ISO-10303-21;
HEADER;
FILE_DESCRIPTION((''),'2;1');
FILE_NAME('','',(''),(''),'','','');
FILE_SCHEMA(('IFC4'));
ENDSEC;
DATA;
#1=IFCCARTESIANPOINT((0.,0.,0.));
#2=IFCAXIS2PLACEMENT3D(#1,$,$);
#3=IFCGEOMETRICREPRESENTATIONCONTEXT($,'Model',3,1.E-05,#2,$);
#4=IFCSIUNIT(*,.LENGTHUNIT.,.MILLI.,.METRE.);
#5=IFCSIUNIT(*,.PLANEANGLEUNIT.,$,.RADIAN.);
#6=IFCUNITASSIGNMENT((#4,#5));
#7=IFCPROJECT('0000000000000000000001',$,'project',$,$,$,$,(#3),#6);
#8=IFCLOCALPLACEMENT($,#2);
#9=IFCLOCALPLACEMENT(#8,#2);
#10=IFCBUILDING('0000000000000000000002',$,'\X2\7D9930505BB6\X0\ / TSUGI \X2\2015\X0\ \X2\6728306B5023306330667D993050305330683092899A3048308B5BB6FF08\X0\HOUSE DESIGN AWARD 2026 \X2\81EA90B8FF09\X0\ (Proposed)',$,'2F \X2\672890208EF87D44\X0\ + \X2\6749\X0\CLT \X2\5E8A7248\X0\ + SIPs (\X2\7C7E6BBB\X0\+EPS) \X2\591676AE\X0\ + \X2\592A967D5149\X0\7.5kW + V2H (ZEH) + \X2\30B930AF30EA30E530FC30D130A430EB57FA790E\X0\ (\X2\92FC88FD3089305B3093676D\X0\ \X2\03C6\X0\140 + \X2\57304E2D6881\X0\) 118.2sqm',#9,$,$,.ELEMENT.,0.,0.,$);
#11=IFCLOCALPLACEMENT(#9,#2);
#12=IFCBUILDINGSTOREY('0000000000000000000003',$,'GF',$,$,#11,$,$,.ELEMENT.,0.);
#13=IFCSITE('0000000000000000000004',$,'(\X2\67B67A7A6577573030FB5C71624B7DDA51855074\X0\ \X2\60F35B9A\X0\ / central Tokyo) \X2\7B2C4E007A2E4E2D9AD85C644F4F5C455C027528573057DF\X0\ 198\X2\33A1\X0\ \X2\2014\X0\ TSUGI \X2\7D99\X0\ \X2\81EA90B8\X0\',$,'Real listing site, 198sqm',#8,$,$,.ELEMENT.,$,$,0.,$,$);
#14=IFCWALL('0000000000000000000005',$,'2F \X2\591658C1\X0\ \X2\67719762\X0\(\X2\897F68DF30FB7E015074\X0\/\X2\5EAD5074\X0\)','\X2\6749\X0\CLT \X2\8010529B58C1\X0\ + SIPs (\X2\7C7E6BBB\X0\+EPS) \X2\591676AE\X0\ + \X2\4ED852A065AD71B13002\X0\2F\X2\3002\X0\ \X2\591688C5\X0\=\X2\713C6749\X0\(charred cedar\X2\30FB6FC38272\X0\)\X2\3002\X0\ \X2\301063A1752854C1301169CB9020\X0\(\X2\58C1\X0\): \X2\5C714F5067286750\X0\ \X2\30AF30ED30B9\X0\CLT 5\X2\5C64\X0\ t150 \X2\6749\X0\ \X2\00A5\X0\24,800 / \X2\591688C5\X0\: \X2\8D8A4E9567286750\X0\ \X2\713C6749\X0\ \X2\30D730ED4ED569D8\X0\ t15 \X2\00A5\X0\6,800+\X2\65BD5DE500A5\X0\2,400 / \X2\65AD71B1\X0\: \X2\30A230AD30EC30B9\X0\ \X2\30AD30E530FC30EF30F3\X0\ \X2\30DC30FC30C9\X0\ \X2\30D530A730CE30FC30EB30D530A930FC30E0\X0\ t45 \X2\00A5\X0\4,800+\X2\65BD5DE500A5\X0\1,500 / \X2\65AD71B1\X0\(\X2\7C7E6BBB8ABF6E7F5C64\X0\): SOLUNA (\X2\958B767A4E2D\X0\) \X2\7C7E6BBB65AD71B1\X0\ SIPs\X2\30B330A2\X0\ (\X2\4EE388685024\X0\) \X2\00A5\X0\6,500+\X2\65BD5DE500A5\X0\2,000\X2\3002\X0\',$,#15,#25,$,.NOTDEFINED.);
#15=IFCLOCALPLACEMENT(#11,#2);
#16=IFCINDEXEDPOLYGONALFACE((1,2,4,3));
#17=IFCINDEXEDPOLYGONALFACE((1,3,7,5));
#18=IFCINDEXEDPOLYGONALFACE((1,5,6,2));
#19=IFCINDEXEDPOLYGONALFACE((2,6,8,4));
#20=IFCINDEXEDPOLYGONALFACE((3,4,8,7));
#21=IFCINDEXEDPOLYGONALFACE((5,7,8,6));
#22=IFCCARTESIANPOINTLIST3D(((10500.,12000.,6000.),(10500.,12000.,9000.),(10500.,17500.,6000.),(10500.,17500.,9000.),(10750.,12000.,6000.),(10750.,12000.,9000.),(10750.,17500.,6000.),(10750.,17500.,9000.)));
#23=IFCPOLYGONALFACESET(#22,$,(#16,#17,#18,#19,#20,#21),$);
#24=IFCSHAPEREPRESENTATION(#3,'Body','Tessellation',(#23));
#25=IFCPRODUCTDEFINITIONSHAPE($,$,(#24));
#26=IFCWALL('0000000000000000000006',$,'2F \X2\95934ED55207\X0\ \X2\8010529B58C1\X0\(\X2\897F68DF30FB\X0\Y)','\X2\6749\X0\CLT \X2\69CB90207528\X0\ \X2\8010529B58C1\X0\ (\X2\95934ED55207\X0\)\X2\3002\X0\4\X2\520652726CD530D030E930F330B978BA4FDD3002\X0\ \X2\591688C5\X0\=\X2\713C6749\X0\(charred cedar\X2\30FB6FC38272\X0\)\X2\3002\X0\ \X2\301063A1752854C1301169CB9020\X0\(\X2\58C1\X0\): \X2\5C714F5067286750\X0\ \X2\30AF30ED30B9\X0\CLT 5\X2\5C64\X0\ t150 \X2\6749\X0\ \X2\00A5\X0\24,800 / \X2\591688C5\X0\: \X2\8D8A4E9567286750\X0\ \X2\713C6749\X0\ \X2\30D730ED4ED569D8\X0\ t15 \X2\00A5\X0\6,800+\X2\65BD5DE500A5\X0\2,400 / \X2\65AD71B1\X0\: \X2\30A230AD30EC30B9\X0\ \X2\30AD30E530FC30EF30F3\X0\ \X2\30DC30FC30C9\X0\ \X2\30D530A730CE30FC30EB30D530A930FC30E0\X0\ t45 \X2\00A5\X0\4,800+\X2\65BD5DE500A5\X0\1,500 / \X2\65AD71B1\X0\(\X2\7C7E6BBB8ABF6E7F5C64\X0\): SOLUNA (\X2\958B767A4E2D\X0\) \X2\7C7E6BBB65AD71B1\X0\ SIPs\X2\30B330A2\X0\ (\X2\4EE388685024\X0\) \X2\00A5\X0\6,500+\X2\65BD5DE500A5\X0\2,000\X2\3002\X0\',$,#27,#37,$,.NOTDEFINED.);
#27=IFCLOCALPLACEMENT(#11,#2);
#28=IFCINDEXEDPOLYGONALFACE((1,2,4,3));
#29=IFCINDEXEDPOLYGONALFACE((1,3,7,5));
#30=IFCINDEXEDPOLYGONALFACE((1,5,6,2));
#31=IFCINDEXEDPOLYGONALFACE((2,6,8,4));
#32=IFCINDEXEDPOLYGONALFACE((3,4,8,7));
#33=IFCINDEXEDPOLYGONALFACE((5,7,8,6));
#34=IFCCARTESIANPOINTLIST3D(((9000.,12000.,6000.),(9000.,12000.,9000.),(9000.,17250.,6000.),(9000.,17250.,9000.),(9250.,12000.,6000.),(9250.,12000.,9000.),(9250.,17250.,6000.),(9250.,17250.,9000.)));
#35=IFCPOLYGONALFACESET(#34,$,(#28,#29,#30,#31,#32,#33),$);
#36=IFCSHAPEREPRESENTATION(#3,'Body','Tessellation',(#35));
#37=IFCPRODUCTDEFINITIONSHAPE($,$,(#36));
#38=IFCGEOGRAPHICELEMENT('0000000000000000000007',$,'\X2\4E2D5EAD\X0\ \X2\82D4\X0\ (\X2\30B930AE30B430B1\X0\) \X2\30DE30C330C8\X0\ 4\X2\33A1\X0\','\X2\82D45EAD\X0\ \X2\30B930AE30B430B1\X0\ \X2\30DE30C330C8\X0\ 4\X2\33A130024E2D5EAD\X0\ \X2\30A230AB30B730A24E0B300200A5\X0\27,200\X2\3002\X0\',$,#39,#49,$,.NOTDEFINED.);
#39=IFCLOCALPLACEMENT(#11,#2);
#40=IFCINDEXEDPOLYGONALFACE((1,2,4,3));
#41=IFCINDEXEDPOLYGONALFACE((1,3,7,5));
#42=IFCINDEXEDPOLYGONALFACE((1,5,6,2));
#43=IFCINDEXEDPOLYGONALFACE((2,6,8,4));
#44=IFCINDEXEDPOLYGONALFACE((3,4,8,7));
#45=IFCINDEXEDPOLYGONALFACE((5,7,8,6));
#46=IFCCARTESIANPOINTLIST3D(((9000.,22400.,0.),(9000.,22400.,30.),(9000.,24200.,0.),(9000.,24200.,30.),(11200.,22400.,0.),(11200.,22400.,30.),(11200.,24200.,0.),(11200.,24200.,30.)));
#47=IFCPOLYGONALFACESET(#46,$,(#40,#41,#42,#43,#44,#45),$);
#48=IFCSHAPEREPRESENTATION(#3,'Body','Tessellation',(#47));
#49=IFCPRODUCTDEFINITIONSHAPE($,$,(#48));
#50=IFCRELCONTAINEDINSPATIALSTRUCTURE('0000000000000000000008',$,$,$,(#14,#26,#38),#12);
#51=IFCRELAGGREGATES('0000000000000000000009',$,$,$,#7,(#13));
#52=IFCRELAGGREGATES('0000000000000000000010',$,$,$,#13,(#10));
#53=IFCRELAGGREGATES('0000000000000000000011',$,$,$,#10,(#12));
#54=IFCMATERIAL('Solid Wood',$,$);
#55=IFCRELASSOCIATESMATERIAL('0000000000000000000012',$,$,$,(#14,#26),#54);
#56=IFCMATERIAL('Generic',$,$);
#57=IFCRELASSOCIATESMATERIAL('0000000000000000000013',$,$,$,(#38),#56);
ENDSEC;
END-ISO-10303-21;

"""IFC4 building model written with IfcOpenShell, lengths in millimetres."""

from ifc_helpers import new_model, si_unit, frame, frame_2d, origin, place, context, project, spatial, rectangle, extrude, material, element, save


model = new_model("IFC4")

# Units and contexts
model_context = context("Model", 3, precision=1e-05, world=origin())
ifc_project = project(units=[si_unit("LENGTHUNIT", "METRE", prefix="MILLI"), si_unit("PLANEANGLEUNIT", "RADIAN")], contexts=[model_context])

# Site, building, storey
site_placement = place(None, origin())
site = spatial("IfcSite", under=ifc_project, at=site_placement, Name="(架空敷地・山手線内側 想定 / central Tokyo) 第一種中高層住居専用地域 198㎡ — TSUGI 継 自邸", ObjectType="Real listing site, 198sqm", CompositionType="ELEMENT", RefElevation=0.0)
building_placement = place(site_placement, origin())
building = spatial("IfcBuilding", under=site, at=building_placement, Name="継ぐ家 / TSUGI ― 木に倣って継ぐことを覚える家（HOUSE DESIGN AWARD 2026 自邸） (Proposed)", ObjectType="2F 木造軸組 + 杉CLT 床版 + SIPs (籾殻+EPS) 外皮 + 太陽光7.5kW + V2H (ZEH) + スクリューパイル基礎 (鋼製らせん杭 φ140 + 地中梁) 118.2sqm", CompositionType="ELEMENT", ElevationOfRefHeight=0.0, ElevationOfTerrain=0.0)
storey_placement = place(building_placement, origin())
storey = spatial("IfcBuildingStorey", under=building, at=storey_placement, Name="GF", CompositionType="ELEMENT", Elevation=0.0)

# Shared definitions
ifc_material_1 = material(Name="Generic")

# Shared definitions
ifc_material_2 = material(Name="Solid Wood")

# Walls
wall_1_placement = place(storey_placement, frame((5250.0, 6000.0, 3000.0)))
element("IfcWall", 1, at=wall_1_placement, inside=storey, material=ifc_material_2, Name="2F 外壁 東面(西棟・縁側/庭側)", Description="杉CLT 耐力壁 + SIPs (籾殻+EPS) 外皮 + 付加断熱。2F。 外装=焼杉(charred cedar・濃色)。 【採用品】構造(壁): 山佐木材 クロスCLT 5層 t150 杉 ¥24,800 / 外装: 越井木材 焼杉 プロ仕様 t15 ¥6,800+施工¥2,400 / 断熱: アキレス キューワン ボード フェノールフォーム t45 ¥4,800+施工¥1,500 / 断熱(籾殻調湿層): SOLUNA (開発中) 籾殻断熱 SIPsコア (代表値) ¥6,500+施工¥2,000。", PredefinedType="NOTDEFINED", context=model_context, shape_type="SweptSolid", body=[
    extrude(rectangle(XDim=250.0, YDim=5500.0, at=frame_2d((125.0, 2750.0))), frame((5250.0, 6000.0, 3000.0)), (0.0, 0.0, 1.0), 3000.0),
])
wall_2_placement = place(storey_placement, frame((4500.0, 6000.0, 3000.0)))
element("IfcWall", 2, at=wall_2_placement, inside=storey, material=ifc_material_2, Name="2F 間仕切 耐力壁(西棟・Y)", Description="杉CLT 構造用 耐力壁 (間仕切)。4分割法バランス確保。 外装=焼杉(charred cedar・濃色)。 【採用品】構造(壁): 山佐木材 クロスCLT 5層 t150 杉 ¥24,800 / 外装: 越井木材 焼杉 プロ仕様 t15 ¥6,800+施工¥2,400 / 断熱: アキレス キューワン ボード フェノールフォーム t45 ¥4,800+施工¥1,500 / 断熱(籾殻調湿層): SOLUNA (開発中) 籾殻断熱 SIPsコア (代表値) ¥6,500+施工¥2,000。", PredefinedType="NOTDEFINED", context=model_context, shape_type="SweptSolid", body=[
    extrude(rectangle(XDim=250.0, YDim=5250.0, at=frame_2d((125.0, 2625.0))), frame((4500.0, 6000.0, 3000.0)), (0.0, 0.0, 1.0), 3000.0),
])

# Geographic element
geographic_element_1_placement = place(storey_placement, frame((4500.0, 11200.0, 0.0)))
element("IfcGeographicElement", 3, at=geographic_element_1_placement, inside=storey, material=ifc_material_1, Name="中庭 苔 (スギゴケ) マット 4㎡", Description="苔庭 スギゴケ マット 4㎡。中庭 アカシア下。¥27,200。", PredefinedType="NOTDEFINED", context=model_context, shape_type="SweptSolid", body=[
    extrude(rectangle(XDim=2200.0, YDim=1800.0, at=frame_2d((1100.0, 900.0))), frame((4500.0, 11200.0, 0.0)), (0.0, 0.0, 1.0), 30.0),
])

save(model, "model.ifc")
